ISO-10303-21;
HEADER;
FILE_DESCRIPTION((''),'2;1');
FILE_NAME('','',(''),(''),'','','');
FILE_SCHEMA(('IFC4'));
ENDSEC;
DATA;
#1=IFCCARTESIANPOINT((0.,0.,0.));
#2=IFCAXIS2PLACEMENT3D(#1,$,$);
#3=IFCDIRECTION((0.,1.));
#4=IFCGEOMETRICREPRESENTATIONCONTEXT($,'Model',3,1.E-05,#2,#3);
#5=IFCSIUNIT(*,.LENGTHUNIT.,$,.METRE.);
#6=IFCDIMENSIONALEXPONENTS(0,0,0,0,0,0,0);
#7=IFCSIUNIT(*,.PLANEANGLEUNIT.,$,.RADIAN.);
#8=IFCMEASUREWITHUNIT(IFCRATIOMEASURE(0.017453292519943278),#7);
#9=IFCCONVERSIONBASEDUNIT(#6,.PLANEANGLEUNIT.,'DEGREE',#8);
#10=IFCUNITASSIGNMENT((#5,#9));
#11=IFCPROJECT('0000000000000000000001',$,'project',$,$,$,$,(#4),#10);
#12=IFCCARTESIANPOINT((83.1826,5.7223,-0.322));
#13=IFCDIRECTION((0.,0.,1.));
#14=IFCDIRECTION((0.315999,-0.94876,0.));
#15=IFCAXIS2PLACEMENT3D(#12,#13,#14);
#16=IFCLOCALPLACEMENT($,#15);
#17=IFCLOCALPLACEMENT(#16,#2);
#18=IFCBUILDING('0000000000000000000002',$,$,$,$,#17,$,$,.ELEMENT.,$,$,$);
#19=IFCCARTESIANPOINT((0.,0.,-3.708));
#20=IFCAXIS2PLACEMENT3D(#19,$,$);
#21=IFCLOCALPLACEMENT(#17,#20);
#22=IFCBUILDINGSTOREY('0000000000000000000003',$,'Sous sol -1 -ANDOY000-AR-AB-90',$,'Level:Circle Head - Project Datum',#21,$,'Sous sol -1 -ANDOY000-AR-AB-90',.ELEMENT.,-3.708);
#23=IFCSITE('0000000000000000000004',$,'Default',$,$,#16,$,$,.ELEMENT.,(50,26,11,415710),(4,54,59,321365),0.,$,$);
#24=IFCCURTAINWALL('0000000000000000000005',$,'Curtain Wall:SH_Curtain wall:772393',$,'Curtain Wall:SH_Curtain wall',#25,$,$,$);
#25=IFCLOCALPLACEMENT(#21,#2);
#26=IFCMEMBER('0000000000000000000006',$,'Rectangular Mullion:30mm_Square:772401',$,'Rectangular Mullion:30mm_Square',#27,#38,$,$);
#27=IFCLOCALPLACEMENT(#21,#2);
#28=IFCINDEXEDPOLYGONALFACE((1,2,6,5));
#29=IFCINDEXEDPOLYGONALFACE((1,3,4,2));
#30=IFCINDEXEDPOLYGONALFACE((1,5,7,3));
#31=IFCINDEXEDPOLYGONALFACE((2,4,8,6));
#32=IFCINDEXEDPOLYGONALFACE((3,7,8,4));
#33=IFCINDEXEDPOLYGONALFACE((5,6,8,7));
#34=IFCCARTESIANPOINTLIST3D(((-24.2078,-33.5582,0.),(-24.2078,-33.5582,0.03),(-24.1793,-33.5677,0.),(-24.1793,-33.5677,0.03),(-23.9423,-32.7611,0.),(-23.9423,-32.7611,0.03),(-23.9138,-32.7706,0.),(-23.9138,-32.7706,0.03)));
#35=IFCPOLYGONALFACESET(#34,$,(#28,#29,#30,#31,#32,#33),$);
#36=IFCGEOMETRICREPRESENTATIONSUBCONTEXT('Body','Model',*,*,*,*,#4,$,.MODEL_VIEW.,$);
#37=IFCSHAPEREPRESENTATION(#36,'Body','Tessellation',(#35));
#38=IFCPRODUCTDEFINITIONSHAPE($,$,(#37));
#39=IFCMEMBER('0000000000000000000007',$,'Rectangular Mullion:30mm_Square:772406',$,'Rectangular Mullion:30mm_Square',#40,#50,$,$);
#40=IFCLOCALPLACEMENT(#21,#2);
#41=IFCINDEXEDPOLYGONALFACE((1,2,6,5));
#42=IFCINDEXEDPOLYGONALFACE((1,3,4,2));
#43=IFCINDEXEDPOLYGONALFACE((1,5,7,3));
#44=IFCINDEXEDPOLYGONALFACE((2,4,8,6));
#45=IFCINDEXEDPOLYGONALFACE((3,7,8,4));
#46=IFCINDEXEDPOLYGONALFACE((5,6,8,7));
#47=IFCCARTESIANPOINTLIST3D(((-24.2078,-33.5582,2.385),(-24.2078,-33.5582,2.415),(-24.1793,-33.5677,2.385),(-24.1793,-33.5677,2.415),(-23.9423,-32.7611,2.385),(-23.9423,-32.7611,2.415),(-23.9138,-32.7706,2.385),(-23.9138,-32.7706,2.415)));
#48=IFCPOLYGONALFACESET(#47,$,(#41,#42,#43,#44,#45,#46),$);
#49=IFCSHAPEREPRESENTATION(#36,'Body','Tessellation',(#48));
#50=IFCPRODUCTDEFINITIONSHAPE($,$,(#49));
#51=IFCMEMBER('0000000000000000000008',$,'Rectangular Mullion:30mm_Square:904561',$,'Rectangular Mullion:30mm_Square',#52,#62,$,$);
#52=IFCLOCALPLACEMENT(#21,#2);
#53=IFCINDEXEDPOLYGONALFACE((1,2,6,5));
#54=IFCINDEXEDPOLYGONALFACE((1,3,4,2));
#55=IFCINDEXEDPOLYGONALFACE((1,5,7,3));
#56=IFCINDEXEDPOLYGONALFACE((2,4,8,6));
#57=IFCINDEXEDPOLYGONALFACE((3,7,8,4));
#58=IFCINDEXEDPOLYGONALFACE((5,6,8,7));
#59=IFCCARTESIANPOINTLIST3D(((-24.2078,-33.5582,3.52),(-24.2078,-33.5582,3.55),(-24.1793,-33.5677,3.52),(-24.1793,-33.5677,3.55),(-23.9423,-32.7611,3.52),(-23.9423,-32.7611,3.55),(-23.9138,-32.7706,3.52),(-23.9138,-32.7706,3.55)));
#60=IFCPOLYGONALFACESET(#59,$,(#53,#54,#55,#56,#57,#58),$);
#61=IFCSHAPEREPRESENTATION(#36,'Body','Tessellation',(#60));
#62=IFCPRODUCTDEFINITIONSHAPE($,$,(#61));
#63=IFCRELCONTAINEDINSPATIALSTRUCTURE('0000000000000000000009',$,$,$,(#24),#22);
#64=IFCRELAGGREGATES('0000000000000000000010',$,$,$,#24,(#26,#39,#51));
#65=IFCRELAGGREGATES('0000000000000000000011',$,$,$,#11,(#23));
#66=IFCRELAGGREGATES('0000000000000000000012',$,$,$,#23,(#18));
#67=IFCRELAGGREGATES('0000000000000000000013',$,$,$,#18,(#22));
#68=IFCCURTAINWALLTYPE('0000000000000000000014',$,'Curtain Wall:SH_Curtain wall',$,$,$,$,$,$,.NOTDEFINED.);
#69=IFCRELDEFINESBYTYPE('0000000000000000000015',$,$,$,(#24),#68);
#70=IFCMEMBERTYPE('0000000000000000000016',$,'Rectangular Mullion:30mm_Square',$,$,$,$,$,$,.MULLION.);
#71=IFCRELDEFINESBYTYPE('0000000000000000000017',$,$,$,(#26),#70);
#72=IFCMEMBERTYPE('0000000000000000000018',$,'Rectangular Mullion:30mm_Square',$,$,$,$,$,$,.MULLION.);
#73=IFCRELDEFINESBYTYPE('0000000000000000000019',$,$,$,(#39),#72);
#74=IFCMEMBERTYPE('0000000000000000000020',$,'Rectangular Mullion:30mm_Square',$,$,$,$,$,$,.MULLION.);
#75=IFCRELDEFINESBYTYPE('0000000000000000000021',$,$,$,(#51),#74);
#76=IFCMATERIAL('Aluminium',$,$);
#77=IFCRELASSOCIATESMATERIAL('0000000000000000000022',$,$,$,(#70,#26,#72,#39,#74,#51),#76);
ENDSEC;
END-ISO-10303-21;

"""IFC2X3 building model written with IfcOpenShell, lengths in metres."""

from ifc_helpers import new_model, entity, si_unit, converted_unit, direction, frame, origin, origin_2d_with_axis, place, context, subcontext, project, spatial, rectangle, extrude, source, transform, mapped, material, type_object, type_shapes, element, aggregate, save


model = new_model("IFC2X3")

# Units and contexts
model_context = context("Model", 3, precision=1e-05, world=origin(), true_north=direction((0.0, 1.0)))
body_context = subcontext(model_context, "Body", "Model", "MODEL_VIEW")
ifc_project = project(units=[si_unit("LENGTHUNIT", "METRE"), converted_unit("PLANEANGLEUNIT", "DEGREE", entity("IfcRatioMeasure", 0.017453292519943278), si_unit("PLANEANGLEUNIT", "RADIAN"), dimensions=[0, 0, 0, 0, 0, 0, 0])], contexts=[model_context])

# Site, building, storey
site_placement = place(None, frame((83.1826, 5.7223, -0.322), z_axis=(0.0, 0.0, 1.0), x_axis=(0.315999, -0.94876, 0.0)))
site = spatial("IfcSite", under=ifc_project, at=site_placement, Name="Default", CompositionType="ELEMENT", RefLatitude=(50, 26, 11, 415710), RefLongitude=(4, 54, 59, 321365), RefElevation=0.0)
building_placement = place(site_placement, origin())
building = spatial("IfcBuilding", under=site, at=building_placement, CompositionType="ELEMENT")
storey_placement = place(building_placement, frame((0.0, 0.0, -3.708)))
storey = spatial("IfcBuildingStorey", under=building, at=storey_placement, Name="Sous sol -1 -ANDOY000-AR-AB-90", ObjectType="Level:Circle Head - Project Datum", LongName="Sous sol -1 -ANDOY000-AR-AB-90", CompositionType="ELEMENT", Elevation=-3.708)

# Curtain wall
curtain_wall_type = type_object("IfcCurtainWallType", Name="Curtain Wall:SH_Curtain wall", PredefinedType="NOTDEFINED")
curtain_wall_1_placement = place(storey_placement, frame((0.0, 0.0, 3.708)))
curtain_wall_1 = element("IfcCurtainWall", 1, at=curtain_wall_1_placement, inside=storey, type_object=curtain_wall_type, Name="Curtain Wall:SH_Curtain wall:772393", ObjectType="Curtain Wall:SH_Curtain wall")
ifc_material_1 = material(Name="Aluminium")

# Members
member_type_1 = type_object("IfcMemberType", Name="Rectangular Mullion:30mm_Square", PredefinedType="MULLION", material=ifc_material_1)
shared_shape_1 = source(origin(), body_context, "Body", "SweptSolid", [
    extrude(rectangle(XDim=0.03, YDim=0.03, at=origin_2d_with_axis()), frame((-0.015, 0.0, -0.8402), z_axis=(0.0, 0.0, 1.0), x_axis=(0.0, -1.0, 0.0)), (0.0, 0.0, 1.0), 0.8402),
])
type_shapes(member_type_1, [shared_shape_1])
member_1_placement = place(curtain_wall_1_placement, frame((-24.1935, -33.563, -3.708), z_axis=(-0.316, -0.948759, 0.0), x_axis=(0.0, 0.0, -1.0)))
member_1 = element("IfcMember", 2, at=member_1_placement, type_object=member_type_1, material=ifc_material_1, Name="Rectangular Mullion:30mm_Square:772401", ObjectType="Rectangular Mullion:30mm_Square", context=body_context, shape_type="MappedRepresentation", body=[
    mapped(shared_shape_1, transform((0.0, 0.0, 0.0), scale=1.0)),
])
member_type_2 = type_object("IfcMemberType", Name="Rectangular Mullion:30mm_Square", PredefinedType="MULLION", material=ifc_material_1)
shared_shape_2 = source(origin(), body_context, "Body", "SweptSolid", [
    extrude(rectangle(XDim=0.03, YDim=0.03, at=origin_2d_with_axis()), frame((0.0, 0.0, -0.8402), z_axis=(0.0, 0.0, 1.0), x_axis=(0.0, -1.0, 0.0)), (0.0, 0.0, 1.0), 0.8402),
])
type_shapes(member_type_2, [shared_shape_2])
member_2_placement = place(curtain_wall_1_placement, frame((-23.928, -32.7658, -1.308), z_axis=(0.316, 0.948759, 0.0), x_axis=(0.0, 0.0, 1.0)))
member_2 = element("IfcMember", 3, at=member_2_placement, type_object=member_type_2, material=ifc_material_1, Name="Rectangular Mullion:30mm_Square:772406", ObjectType="Rectangular Mullion:30mm_Square", context=body_context, shape_type="MappedRepresentation", body=[
    mapped(shared_shape_2, transform((0.0, 0.0, 0.0), scale=1.0)),
])
member_type_3 = type_object("IfcMemberType", Name="Rectangular Mullion:30mm_Square", PredefinedType="MULLION", material=ifc_material_1)
shared_shape_3 = source(origin(), body_context, "Body", "SweptSolid", [
    extrude(rectangle(XDim=0.03, YDim=0.03, at=origin_2d_with_axis()), frame((-0.015, 0.0, -0.8402), z_axis=(0.0, 0.0, 1.0), x_axis=(0.0, -1.0, 0.0)), (0.0, 0.0, 1.0), 0.8402),
])
type_shapes(member_type_3, [shared_shape_3])
member_3_placement = place(curtain_wall_1_placement, frame((-23.928, -32.7658, -0.158), z_axis=(0.316, 0.948759, 0.0), x_axis=(0.0, 0.0, 1.0)))
member_3 = element("IfcMember", 4, at=member_3_placement, type_object=member_type_3, material=ifc_material_1, Name="Rectangular Mullion:30mm_Square:904561", ObjectType="Rectangular Mullion:30mm_Square", context=body_context, shape_type="MappedRepresentation", body=[
    mapped(shared_shape_3, transform((0.0, 0.0, 0.0), scale=1.0)),
])

aggregate(curtain_wall_1, [member_1, member_2, member_3])

save(model, "model.ifc")
